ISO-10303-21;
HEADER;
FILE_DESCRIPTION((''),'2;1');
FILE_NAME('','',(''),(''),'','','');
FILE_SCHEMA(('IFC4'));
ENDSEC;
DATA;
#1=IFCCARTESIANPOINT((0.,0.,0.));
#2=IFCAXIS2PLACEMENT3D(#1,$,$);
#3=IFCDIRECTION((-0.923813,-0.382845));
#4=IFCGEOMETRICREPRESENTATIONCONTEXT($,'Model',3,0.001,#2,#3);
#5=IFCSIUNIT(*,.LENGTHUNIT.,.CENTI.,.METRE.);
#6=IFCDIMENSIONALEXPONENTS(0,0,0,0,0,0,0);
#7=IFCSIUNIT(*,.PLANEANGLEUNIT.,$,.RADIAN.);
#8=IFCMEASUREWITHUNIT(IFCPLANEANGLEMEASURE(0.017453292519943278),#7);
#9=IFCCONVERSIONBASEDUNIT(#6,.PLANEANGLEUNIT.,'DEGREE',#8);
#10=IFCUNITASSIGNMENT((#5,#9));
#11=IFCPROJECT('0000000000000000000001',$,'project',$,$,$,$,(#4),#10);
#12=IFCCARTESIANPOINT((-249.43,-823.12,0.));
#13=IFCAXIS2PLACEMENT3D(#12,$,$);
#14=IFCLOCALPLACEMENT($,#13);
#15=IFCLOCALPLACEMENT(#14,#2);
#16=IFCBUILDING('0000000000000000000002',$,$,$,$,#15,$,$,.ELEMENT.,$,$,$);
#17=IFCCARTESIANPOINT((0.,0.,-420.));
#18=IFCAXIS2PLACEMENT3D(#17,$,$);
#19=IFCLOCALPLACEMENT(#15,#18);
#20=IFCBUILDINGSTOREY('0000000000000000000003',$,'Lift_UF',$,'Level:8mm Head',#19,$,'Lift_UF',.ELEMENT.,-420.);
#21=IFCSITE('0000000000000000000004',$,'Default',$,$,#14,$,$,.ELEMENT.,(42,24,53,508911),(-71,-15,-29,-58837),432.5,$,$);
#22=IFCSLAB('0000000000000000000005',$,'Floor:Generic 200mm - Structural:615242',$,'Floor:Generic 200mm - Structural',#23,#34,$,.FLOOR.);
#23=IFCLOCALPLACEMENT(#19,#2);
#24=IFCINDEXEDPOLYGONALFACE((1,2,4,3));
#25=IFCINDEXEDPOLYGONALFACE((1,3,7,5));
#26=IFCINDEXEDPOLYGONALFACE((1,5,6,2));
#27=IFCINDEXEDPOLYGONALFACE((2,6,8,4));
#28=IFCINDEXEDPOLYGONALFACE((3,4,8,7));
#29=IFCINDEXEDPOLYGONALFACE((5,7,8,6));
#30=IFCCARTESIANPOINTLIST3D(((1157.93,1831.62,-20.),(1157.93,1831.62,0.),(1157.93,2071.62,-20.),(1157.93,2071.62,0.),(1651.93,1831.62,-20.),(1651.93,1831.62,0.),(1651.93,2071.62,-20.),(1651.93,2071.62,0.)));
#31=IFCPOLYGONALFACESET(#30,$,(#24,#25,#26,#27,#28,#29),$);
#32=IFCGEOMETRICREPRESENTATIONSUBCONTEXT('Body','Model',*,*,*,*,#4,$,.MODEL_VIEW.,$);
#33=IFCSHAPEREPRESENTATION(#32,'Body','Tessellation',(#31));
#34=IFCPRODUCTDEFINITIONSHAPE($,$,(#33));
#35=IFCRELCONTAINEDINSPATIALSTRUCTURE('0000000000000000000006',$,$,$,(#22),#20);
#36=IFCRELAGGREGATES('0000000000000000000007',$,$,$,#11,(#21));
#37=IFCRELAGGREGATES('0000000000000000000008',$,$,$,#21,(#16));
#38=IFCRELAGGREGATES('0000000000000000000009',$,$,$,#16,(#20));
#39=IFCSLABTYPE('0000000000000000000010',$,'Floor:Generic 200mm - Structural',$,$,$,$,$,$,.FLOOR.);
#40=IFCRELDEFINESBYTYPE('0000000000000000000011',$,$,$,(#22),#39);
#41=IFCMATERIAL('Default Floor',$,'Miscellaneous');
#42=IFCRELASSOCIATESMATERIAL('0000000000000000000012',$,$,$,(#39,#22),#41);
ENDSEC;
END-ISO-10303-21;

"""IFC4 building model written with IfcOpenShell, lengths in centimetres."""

from ifc_helpers import new_model, entity, si_unit, converted_unit, direction, frame, origin, place, context, subcontext, project, spatial, indexed_curve, outline, extrude, material, type_object, element, save


model = new_model("IFC4")

# Units and contexts
model_context = context("Model", 3, precision=0.001, world=origin(), true_north=direction((-0.923813, -0.382845)))
body_context = subcontext(model_context, "Body", "Model", "MODEL_VIEW")
ifc_project = project(units=[si_unit("LENGTHUNIT", "METRE", prefix="CENTI"), converted_unit("PLANEANGLEUNIT", "DEGREE", entity("IfcPlaneAngleMeasure", 0.017453292519943278), si_unit("PLANEANGLEUNIT", "RADIAN"), dimensions=[0, 0, 0, 0, 0, 0, 0])], contexts=[model_context])

# Site, building, storey
site_placement = place(None, frame((-249.43, -823.12, 0.0)))
site = spatial("IfcSite", under=ifc_project, at=site_placement, Name="Default", CompositionType="ELEMENT", RefLatitude=(42, 24, 53, 508911), RefLongitude=(-71, -15, -29, -58837), RefElevation=432.5)
building_placement = place(site_placement, origin())
building = spatial("IfcBuilding", under=site, at=building_placement, CompositionType="ELEMENT")
storey_placement = place(building_placement, frame((0.0, 0.0, -420.0)))
storey = spatial("IfcBuildingStorey", under=building, at=storey_placement, Name="Lift_UF", ObjectType="Level:8mm Head", LongName="Lift_UF", CompositionType="ELEMENT", Elevation=-420.0)

# Slab
ifc_material = material(Name="Default Floor", Category="Miscellaneous")
slab_type = type_object("IfcSlabType", Name="Floor:Generic 200mm - Structural", PredefinedType="FLOOR", material=ifc_material)
slab_placement = place(storey_placement, origin())
element("IfcSlab", 1, at=slab_placement, inside=storey, type_object=slab_type, material=ifc_material, Name="Floor:Generic 200mm - Structural:615242", ObjectType="Floor:Generic 200mm - Structural", PredefinedType="FLOOR", context=body_context, shape_type="SweptSolid", body=[
    extrude(outline(indexed_curve([(-120.0, -247.0), (120.0, -247.0), (120.0, 247.0), (-120.0, 247.0), (-120.0, -247.0)], self_intersect=False)), frame((1404.93, 1951.62, 0.0), z_axis=(0.0, 0.0, -1.0), x_axis=(0.0, 1.0, 0.0)), (0.0, 0.0, 1.0), 20.0),
])

save(model, "model.ifc")
